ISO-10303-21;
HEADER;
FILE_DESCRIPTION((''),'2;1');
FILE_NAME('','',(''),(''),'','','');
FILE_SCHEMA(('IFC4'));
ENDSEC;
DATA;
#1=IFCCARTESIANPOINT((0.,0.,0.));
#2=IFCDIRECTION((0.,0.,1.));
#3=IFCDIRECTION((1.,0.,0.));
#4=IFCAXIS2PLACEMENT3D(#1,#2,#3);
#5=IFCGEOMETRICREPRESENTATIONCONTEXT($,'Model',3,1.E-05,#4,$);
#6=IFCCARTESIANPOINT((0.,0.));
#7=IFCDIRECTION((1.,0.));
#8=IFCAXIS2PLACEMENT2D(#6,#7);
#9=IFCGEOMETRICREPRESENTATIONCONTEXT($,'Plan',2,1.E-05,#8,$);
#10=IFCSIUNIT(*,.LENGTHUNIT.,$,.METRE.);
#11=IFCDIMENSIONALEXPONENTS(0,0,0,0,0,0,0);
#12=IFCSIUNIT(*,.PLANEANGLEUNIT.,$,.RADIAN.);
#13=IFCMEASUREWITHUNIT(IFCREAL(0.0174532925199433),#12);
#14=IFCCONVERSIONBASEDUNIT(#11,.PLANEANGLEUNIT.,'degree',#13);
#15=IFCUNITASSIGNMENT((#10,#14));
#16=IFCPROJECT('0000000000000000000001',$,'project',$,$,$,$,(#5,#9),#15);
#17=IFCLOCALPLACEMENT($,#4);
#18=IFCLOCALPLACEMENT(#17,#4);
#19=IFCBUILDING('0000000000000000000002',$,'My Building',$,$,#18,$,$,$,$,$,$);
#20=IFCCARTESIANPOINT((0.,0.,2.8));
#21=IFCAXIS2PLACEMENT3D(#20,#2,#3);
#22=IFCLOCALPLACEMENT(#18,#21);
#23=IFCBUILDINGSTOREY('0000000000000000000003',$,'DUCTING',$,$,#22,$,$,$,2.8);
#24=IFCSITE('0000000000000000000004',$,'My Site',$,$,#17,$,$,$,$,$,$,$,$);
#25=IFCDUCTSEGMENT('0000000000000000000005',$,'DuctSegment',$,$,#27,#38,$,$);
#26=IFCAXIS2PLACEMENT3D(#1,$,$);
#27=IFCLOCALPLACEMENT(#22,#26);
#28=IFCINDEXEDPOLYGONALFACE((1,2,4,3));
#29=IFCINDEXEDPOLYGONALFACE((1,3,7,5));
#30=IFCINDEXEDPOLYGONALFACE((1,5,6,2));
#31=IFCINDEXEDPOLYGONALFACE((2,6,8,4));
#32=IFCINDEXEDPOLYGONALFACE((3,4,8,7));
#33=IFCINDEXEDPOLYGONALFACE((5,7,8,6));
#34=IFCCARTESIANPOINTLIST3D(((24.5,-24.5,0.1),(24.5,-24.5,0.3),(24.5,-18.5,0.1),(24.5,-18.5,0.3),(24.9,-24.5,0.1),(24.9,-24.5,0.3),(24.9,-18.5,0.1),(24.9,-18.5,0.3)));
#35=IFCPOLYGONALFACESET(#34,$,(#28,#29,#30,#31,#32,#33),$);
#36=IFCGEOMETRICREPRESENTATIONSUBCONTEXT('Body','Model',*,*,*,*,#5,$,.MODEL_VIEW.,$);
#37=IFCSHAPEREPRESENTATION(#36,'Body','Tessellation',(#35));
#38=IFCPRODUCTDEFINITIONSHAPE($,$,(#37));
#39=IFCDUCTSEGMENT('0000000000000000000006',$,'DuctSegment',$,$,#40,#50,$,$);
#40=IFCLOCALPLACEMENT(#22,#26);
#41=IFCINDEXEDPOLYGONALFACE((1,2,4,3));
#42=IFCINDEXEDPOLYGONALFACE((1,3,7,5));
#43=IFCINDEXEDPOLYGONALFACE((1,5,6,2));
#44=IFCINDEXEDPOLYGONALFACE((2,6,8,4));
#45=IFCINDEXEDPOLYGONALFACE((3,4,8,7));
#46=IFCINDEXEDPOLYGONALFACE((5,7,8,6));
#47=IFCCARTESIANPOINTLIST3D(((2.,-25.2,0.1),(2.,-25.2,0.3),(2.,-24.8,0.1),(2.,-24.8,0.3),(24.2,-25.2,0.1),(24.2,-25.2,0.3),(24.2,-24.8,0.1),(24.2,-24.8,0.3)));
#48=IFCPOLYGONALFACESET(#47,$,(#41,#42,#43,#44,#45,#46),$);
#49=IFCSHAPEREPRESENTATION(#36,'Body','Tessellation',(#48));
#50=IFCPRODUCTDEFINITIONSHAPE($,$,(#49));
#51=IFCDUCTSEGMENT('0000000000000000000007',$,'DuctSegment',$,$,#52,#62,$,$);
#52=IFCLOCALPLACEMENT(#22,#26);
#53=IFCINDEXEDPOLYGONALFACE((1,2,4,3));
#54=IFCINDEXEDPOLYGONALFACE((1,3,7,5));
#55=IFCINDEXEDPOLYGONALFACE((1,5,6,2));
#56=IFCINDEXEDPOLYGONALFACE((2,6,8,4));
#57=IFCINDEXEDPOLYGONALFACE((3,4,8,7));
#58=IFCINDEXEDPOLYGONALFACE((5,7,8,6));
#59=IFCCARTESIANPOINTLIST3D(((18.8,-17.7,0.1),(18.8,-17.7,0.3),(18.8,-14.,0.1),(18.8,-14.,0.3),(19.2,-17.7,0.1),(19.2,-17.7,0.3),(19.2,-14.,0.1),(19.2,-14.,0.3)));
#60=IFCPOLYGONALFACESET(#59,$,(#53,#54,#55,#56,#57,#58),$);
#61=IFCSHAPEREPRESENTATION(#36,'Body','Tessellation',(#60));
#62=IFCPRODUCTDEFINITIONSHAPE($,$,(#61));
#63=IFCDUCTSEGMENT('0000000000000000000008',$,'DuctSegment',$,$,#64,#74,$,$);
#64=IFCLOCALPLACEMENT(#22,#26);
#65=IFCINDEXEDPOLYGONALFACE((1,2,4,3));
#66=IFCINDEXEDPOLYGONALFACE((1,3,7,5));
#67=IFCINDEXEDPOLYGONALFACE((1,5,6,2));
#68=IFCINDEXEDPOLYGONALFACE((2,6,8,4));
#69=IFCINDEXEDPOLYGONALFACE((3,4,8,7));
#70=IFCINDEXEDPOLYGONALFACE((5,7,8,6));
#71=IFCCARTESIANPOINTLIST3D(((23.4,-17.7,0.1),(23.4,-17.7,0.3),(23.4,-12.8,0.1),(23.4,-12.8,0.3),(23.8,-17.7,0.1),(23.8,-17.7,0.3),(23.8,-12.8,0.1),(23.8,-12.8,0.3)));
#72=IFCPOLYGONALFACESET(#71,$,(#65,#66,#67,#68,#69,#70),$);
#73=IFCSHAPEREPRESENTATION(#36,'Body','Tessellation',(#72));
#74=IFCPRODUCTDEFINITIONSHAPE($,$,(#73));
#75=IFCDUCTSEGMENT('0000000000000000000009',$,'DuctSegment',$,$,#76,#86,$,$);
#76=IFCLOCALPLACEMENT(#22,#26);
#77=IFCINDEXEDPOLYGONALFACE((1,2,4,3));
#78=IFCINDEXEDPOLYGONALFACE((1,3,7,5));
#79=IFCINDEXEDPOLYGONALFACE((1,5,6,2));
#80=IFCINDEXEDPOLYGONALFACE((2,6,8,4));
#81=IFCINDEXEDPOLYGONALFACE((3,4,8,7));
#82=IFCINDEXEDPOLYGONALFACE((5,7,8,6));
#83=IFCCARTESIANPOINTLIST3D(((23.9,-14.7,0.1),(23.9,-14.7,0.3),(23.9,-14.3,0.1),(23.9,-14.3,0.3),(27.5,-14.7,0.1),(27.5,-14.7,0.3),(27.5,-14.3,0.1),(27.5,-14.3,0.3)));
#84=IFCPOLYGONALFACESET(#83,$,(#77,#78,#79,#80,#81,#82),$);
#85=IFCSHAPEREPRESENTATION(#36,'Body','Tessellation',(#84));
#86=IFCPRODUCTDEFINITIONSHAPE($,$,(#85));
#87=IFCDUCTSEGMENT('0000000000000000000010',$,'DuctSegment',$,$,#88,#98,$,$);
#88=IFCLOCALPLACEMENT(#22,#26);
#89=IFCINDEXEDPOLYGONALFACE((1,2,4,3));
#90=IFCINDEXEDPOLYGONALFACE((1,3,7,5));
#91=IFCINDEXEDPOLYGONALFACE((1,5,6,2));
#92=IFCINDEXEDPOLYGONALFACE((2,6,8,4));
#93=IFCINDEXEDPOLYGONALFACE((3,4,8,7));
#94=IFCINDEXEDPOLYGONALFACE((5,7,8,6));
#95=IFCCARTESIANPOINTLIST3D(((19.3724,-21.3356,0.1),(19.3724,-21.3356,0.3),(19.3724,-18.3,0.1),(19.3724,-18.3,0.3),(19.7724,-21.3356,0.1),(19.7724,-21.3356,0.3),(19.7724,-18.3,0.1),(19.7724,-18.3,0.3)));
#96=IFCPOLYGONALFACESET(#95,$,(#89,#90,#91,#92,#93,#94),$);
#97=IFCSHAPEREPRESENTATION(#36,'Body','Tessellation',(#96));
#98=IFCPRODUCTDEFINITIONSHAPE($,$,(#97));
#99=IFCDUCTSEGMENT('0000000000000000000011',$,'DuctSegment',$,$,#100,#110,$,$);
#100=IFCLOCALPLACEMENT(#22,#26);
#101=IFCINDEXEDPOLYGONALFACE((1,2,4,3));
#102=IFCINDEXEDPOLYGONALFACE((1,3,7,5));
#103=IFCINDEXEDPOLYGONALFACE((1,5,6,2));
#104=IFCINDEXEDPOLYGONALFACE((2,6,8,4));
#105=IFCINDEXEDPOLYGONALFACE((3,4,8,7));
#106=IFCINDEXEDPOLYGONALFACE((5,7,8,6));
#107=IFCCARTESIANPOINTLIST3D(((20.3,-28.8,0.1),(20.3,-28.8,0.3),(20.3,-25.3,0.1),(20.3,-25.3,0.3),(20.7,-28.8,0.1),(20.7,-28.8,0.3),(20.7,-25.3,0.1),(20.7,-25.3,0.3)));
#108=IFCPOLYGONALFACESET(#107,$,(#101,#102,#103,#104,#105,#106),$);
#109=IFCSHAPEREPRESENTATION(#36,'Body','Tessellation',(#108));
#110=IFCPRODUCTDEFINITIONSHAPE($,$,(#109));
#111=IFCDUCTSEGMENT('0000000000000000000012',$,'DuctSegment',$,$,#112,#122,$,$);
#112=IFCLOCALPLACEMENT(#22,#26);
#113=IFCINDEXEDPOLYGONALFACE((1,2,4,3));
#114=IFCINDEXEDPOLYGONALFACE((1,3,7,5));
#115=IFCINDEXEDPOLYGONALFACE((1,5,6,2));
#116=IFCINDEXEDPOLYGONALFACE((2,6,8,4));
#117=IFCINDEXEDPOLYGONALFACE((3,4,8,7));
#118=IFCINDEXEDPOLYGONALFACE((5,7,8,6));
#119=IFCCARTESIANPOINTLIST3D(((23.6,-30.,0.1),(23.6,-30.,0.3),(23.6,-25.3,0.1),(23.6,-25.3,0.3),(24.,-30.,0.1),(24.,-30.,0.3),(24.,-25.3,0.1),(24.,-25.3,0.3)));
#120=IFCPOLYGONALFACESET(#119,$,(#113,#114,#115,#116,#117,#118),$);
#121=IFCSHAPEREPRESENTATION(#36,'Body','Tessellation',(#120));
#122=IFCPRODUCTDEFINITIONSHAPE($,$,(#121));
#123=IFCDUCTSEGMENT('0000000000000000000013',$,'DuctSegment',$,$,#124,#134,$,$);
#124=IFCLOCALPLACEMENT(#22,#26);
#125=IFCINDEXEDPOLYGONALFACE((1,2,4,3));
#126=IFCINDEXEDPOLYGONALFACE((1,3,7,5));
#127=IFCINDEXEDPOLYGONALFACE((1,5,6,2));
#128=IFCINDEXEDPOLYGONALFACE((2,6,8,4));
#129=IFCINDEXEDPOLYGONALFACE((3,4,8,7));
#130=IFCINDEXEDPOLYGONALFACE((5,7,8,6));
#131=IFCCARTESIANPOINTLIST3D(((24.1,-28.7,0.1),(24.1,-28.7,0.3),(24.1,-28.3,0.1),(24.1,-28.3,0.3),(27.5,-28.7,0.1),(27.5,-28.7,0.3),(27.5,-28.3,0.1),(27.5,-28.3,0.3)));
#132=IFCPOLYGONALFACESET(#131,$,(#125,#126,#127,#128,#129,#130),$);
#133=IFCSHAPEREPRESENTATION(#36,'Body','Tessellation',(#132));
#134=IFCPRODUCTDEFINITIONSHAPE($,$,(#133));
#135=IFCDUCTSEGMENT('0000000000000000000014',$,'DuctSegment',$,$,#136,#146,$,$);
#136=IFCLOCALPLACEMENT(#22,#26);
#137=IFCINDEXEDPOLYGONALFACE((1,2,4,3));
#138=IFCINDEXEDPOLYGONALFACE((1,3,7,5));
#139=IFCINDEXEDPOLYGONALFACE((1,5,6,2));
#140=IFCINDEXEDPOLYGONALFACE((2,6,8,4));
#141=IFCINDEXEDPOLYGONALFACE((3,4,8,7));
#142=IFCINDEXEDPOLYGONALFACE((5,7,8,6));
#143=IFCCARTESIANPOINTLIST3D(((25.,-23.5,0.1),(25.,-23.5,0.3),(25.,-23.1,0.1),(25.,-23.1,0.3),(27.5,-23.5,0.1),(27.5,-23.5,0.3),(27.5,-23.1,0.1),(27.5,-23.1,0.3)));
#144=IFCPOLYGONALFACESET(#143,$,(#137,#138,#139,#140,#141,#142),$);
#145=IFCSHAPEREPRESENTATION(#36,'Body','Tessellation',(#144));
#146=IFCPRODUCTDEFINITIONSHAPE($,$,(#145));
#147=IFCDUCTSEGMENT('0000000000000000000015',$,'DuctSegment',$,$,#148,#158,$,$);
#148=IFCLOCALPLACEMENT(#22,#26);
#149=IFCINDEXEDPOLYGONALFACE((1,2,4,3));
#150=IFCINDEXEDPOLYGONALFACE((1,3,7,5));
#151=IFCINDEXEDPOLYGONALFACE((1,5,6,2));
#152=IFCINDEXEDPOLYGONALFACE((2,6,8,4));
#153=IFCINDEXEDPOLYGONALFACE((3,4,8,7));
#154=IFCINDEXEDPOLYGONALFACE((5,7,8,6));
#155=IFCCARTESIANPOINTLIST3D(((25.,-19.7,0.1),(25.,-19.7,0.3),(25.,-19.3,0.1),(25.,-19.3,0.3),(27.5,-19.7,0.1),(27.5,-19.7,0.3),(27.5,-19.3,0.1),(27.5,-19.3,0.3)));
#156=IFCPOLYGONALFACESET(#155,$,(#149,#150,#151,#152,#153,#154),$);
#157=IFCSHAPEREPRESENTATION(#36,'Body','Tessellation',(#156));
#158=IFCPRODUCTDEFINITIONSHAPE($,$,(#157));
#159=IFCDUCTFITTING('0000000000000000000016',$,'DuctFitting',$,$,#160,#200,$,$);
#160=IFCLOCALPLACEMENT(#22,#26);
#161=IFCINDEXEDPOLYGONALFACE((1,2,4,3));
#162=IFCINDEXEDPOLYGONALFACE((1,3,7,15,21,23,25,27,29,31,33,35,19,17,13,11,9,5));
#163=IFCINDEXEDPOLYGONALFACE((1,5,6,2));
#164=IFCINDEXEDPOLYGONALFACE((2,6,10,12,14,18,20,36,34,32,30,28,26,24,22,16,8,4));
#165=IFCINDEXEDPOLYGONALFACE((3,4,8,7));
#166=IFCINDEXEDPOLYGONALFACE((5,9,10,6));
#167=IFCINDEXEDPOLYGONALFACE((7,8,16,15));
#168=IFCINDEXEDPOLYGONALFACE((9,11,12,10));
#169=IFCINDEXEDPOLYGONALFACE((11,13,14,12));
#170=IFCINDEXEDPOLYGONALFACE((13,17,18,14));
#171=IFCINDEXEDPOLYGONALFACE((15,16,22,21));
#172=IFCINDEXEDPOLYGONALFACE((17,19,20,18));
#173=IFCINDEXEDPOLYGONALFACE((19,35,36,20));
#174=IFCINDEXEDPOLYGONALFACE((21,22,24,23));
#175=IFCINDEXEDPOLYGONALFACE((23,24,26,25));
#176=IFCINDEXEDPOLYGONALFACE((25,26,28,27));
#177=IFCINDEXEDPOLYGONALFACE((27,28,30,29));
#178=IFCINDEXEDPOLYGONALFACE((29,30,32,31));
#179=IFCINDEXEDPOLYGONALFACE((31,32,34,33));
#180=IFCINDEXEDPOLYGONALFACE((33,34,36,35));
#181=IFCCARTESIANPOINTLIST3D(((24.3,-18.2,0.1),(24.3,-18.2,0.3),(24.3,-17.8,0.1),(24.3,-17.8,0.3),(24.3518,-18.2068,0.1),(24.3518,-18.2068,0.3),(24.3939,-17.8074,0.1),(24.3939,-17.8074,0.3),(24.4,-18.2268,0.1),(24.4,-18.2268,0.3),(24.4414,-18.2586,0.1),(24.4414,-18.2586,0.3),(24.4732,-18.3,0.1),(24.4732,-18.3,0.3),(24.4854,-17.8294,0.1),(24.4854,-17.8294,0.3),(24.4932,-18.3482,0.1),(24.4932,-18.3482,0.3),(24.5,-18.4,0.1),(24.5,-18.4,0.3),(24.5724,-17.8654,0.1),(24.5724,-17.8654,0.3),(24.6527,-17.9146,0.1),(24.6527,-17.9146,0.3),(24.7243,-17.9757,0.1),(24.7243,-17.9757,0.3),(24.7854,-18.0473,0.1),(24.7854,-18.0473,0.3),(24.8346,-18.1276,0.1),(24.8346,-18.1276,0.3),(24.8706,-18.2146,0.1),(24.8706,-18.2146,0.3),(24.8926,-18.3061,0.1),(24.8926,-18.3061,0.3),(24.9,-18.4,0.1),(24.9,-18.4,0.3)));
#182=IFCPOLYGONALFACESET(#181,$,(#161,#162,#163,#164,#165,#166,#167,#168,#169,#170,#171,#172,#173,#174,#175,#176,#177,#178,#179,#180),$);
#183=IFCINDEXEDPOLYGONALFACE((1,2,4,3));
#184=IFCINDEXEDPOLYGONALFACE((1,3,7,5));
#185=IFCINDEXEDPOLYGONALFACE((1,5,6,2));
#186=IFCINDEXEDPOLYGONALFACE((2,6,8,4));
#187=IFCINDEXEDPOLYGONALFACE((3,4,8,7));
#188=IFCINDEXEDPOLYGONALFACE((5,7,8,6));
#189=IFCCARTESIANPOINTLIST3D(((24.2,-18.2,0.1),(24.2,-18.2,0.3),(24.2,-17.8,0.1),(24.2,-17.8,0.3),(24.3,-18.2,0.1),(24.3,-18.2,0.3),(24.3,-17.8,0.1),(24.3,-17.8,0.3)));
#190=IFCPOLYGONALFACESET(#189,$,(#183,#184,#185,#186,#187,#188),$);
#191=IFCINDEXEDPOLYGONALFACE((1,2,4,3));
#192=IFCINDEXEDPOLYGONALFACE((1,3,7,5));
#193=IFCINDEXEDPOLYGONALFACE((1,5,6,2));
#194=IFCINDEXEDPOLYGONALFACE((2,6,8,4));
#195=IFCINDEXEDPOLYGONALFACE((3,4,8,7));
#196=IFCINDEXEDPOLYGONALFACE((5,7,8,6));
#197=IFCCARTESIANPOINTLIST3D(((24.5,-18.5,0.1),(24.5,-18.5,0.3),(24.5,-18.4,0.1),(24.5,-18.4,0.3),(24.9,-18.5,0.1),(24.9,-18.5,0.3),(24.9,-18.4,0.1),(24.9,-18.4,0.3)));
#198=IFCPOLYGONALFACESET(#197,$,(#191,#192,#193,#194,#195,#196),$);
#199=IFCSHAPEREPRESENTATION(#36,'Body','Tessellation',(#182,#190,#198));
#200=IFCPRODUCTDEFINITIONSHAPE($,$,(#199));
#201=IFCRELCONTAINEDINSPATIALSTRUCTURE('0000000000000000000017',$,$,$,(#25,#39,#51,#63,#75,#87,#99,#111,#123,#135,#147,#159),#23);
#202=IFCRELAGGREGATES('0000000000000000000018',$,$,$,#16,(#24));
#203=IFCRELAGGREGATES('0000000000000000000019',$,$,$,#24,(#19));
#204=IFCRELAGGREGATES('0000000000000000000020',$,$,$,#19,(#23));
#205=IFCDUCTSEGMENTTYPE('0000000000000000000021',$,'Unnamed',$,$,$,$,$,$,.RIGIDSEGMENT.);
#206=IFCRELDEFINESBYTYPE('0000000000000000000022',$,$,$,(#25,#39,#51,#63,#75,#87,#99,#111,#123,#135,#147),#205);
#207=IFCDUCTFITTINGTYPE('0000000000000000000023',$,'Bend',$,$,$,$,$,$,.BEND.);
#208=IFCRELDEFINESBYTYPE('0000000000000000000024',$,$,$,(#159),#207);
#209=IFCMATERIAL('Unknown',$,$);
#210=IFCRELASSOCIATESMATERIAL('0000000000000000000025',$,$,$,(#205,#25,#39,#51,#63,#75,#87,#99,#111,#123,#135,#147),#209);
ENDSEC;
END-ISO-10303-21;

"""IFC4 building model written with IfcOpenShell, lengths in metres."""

from ifc_helpers import new_model, entity, si_unit, converted_unit, frame, origin_with_axes, origin_2d_with_axis, place, context, subcontext, project, spatial, line, arc, indexed_curve, rectangle, outline, extrude, source, transform, mapped, material, material_profile, profile_set, profile_usage, type_object, type_shapes, element, save


model = new_model("IFC4")

# Units and contexts
model_context = context("Model", 3, precision=1e-05, world=origin_with_axes())
plan_context = context("Plan", 2, precision=1e-05, world=origin_2d_with_axis())
body_context = subcontext(model_context, "Body", "Model", "MODEL_VIEW")
ifc_project = project(units=[si_unit("LENGTHUNIT", "METRE"), converted_unit("PLANEANGLEUNIT", "degree", entity("IfcReal", 0.0174532925199433), si_unit("PLANEANGLEUNIT", "RADIAN"), dimensions=[0, 0, 0, 0, 0, 0, 0])], contexts=[model_context, plan_context])

# Site, building, storey
site_placement = place(None, origin_with_axes())
site = spatial("IfcSite", under=ifc_project, at=site_placement, Name="My Site")
building_placement = place(site_placement, origin_with_axes())
building = spatial("IfcBuilding", under=site, at=building_placement, Name="My Building")
storey_placement = place(building_placement, frame((0.0, 0.0, 2.8), z_axis=(0.0, 0.0, 1.0), x_axis=(1.0, 0.0, 0.0)))
storey = spatial("IfcBuildingStorey", under=building, at=storey_placement, Name="DUCTING", Elevation=2.8)

# Duct segments
ifc_material = material(Name="Unknown")
ifc_material_profile = material_profile(ifc_material, rectangle(XDim=0.4, YDim=0.2))
ifc_profile_set = profile_set([ifc_material_profile])
ifc_profile_usage_1 = profile_usage(ifc_profile_set)
duct_segment_type = type_object("IfcDuctSegmentType", Name="Unnamed", PredefinedType="RIGIDSEGMENT", material=ifc_profile_set)
duct_segment_1_placement = place(storey_placement, frame((24.7, -18.5, 0.2), z_axis=(0.0, -1.0, 0.0), x_axis=(1.0, 0.0, 0.0)))
element("IfcDuctSegment", 1, at=duct_segment_1_placement, inside=storey, type_object=duct_segment_type, material=ifc_profile_usage_1, Name="DuctSegment", context=body_context, shape_type="SweptSolid", body=[
    extrude(rectangle(XDim=0.4, YDim=0.2), origin_with_axes(), (0.0, 0.0, 1.0), 6.0),
])
ifc_profile_usage_2 = profile_usage(ifc_profile_set)
duct_segment_2_placement = place(storey_placement, frame((24.2, -25.0, 0.2), z_axis=(-1.0, 0.0, 0.0), x_axis=(0.0, -1.0, 0.0)))
element("IfcDuctSegment", 2, at=duct_segment_2_placement, inside=storey, type_object=duct_segment_type, material=ifc_profile_usage_2, Name="DuctSegment", context=body_context, shape_type="SweptSolid", body=[
    extrude(rectangle(XDim=0.4, YDim=0.2), origin_with_axes(), (0.0, 0.0, 1.0), 22.2),
])
ifc_profile_usage_3 = profile_usage(ifc_profile_set)
duct_segment_3_placement = place(storey_placement, frame((19.0, -17.7, 0.2), z_axis=(0.0, 1.0, 0.0), x_axis=(-1.0, 0.0, 0.0)))
element("IfcDuctSegment", 3, at=duct_segment_3_placement, inside=storey, type_object=duct_segment_type, material=ifc_profile_usage_3, Name="DuctSegment", context=body_context, shape_type="SweptSolid", body=[
    extrude(rectangle(XDim=0.4, YDim=0.2), origin_with_axes(), (0.0, 0.0, 1.0), 3.7),
])
ifc_profile_usage_4 = profile_usage(ifc_profile_set)
duct_segment_4_placement = place(storey_placement, frame((23.6, -17.7, 0.2), z_axis=(0.0, 1.0, 0.0), x_axis=(-1.0, 0.0, 0.0)))
element("IfcDuctSegment", 4, at=duct_segment_4_placement, inside=storey, type_object=duct_segment_type, material=ifc_profile_usage_4, Name="DuctSegment", context=body_context, shape_type="SweptSolid", body=[
    extrude(rectangle(XDim=0.4, YDim=0.2), origin_with_axes(), (0.0, 0.0, 1.0), 4.9),
])
ifc_profile_usage_5 = profile_usage(ifc_profile_set)
duct_segment_5_placement = place(storey_placement, frame((23.9, -14.5, 0.2), z_axis=(1.0, 0.0, 0.0), x_axis=(0.0, 1.0, 0.0)))
element("IfcDuctSegment", 5, at=duct_segment_5_placement, inside=storey, type_object=duct_segment_type, material=ifc_profile_usage_5, Name="DuctSegment", context=body_context, shape_type="SweptSolid", body=[
    extrude(rectangle(XDim=0.4, YDim=0.2), origin_with_axes(), (0.0, 0.0, 1.0), 3.6),
])
ifc_profile_usage_6 = profile_usage(ifc_profile_set)
duct_segment_6_placement = place(storey_placement, frame((19.5724, -18.3, 0.2), z_axis=(0.0, -1.0, 0.0), x_axis=(1.0, 0.0, 0.0)))
element("IfcDuctSegment", 6, at=duct_segment_6_placement, inside=storey, type_object=duct_segment_type, material=ifc_profile_usage_6, Name="DuctSegment", context=body_context, shape_type="SweptSolid", body=[
    extrude(rectangle(XDim=0.4, YDim=0.2), origin_with_axes(), (0.0, 0.0, 1.0), 3.0356),
])
ifc_profile_usage_7 = profile_usage(ifc_profile_set)
duct_segment_7_placement = place(storey_placement, frame((20.5, -25.3, 0.2), z_axis=(0.0, -1.0, 0.0), x_axis=(1.0, 0.0, 0.0)))
element("IfcDuctSegment", 7, at=duct_segment_7_placement, inside=storey, type_object=duct_segment_type, material=ifc_profile_usage_7, Name="DuctSegment", context=body_context, shape_type="SweptSolid", body=[
    extrude(rectangle(XDim=0.4, YDim=0.2), origin_with_axes(), (0.0, 0.0, 1.0), 3.5),
])
ifc_profile_usage_8 = profile_usage(ifc_profile_set)
duct_segment_8_placement = place(storey_placement, frame((23.8, -25.3, 0.2), z_axis=(0.0, -1.0, 0.0), x_axis=(1.0, 0.0, 0.0)))
element("IfcDuctSegment", 8, at=duct_segment_8_placement, inside=storey, type_object=duct_segment_type, material=ifc_profile_usage_8, Name="DuctSegment", context=body_context, shape_type="SweptSolid", body=[
    extrude(rectangle(XDim=0.4, YDim=0.2), origin_with_axes(), (0.0, 0.0, 1.0), 4.7),
])
ifc_profile_usage_9 = profile_usage(ifc_profile_set)
duct_segment_9_placement = place(storey_placement, frame((24.1, -28.5, 0.2), z_axis=(1.0, 0.0, 0.0), x_axis=(0.0, 1.0, 0.0)))
element("IfcDuctSegment", 9, at=duct_segment_9_placement, inside=storey, type_object=duct_segment_type, material=ifc_profile_usage_9, Name="DuctSegment", context=body_context, shape_type="SweptSolid", body=[
    extrude(rectangle(XDim=0.4, YDim=0.2), origin_with_axes(), (0.0, 0.0, 1.0), 3.4),
])
ifc_profile_usage_10 = profile_usage(ifc_profile_set)
duct_segment_10_placement = place(storey_placement, frame((25.0, -23.3, 0.2), z_axis=(1.0, 0.0, 0.0), x_axis=(0.0, 1.0, 0.0)))
element("IfcDuctSegment", 10, at=duct_segment_10_placement, inside=storey, type_object=duct_segment_type, material=ifc_profile_usage_10, Name="DuctSegment", context=body_context, shape_type="SweptSolid", body=[
    extrude(rectangle(XDim=0.4, YDim=0.2), origin_with_axes(), (0.0, 0.0, 1.0), 2.5),
])
ifc_profile_usage_11 = profile_usage(ifc_profile_set)
duct_segment_11_placement = place(storey_placement, frame((25.0, -19.5, 0.2), z_axis=(1.0, 0.0, 0.0), x_axis=(0.0, 1.0, 0.0)))
element("IfcDuctSegment", 11, at=duct_segment_11_placement, inside=storey, type_object=duct_segment_type, material=ifc_profile_usage_11, Name="DuctSegment", context=body_context, shape_type="SweptSolid", body=[
    extrude(rectangle(XDim=0.4, YDim=0.2), origin_with_axes(), (0.0, 0.0, 1.0), 2.5),
])

# Duct fitting
duct_fitting_type_1 = type_object("IfcDuctFittingType", Name="Bend", PredefinedType="BEND")
shared_shape = source(origin_with_axes(), body_context, "Body", "SweptSolid", [
    extrude(outline(indexed_curve([(-0.2, 0.0), (-0.2586, 0.1414), (-0.4, 0.2), (-0.4, 0.6), (0.0243, 0.4243), (0.2, 0.0)], segments=[arc(1, 2, 3), line(3, 4), arc(4, 5, 6), line(6, 1)])), frame((0.0, -0.1, 0.1), z_axis=(0.0, -1.0, 0.0), x_axis=(1.0, 0.0, 0.0)), (0.0, 0.0, -1.0), 0.2),
    extrude(rectangle(XDim=0.4, YDim=0.2), origin_with_axes(), (0.0, 0.0, 1.0), 0.1),
    extrude(rectangle(XDim=0.4, YDim=0.2), frame((-0.4, 0.0, 0.5), z_axis=(-1.0, 0.0, 0.0), x_axis=(0.0, 0.0, -1.0)), (0.0, 0.0, 1.0), 0.1),
])
type_shapes(duct_fitting_type_1, [shared_shape])
for number, where, z_axis, x_axis, name in (
    (12, (24.2, -18.0, 0.2), (1.0, 0.0, 0.0), (0.0, 1.0, 0.0), "DuctFitting"),
):
    element("IfcDuctFitting", number, at=place(storey_placement, frame(where, z_axis=z_axis, x_axis=x_axis)), inside=storey, type_object=duct_fitting_type_1, Name=name, context=body_context, shape_type="MappedRepresentation", body=[
        mapped(shared_shape, transform((0.0, 0.0, 0.0), x_axis=(1.0, 0.0, 0.0), y_axis=(0.0, 1.0, 0.0), z_axis=(0.0, 0.0, 1.0), scale=1.0)),
    ])

save(model, "model.ifc")
